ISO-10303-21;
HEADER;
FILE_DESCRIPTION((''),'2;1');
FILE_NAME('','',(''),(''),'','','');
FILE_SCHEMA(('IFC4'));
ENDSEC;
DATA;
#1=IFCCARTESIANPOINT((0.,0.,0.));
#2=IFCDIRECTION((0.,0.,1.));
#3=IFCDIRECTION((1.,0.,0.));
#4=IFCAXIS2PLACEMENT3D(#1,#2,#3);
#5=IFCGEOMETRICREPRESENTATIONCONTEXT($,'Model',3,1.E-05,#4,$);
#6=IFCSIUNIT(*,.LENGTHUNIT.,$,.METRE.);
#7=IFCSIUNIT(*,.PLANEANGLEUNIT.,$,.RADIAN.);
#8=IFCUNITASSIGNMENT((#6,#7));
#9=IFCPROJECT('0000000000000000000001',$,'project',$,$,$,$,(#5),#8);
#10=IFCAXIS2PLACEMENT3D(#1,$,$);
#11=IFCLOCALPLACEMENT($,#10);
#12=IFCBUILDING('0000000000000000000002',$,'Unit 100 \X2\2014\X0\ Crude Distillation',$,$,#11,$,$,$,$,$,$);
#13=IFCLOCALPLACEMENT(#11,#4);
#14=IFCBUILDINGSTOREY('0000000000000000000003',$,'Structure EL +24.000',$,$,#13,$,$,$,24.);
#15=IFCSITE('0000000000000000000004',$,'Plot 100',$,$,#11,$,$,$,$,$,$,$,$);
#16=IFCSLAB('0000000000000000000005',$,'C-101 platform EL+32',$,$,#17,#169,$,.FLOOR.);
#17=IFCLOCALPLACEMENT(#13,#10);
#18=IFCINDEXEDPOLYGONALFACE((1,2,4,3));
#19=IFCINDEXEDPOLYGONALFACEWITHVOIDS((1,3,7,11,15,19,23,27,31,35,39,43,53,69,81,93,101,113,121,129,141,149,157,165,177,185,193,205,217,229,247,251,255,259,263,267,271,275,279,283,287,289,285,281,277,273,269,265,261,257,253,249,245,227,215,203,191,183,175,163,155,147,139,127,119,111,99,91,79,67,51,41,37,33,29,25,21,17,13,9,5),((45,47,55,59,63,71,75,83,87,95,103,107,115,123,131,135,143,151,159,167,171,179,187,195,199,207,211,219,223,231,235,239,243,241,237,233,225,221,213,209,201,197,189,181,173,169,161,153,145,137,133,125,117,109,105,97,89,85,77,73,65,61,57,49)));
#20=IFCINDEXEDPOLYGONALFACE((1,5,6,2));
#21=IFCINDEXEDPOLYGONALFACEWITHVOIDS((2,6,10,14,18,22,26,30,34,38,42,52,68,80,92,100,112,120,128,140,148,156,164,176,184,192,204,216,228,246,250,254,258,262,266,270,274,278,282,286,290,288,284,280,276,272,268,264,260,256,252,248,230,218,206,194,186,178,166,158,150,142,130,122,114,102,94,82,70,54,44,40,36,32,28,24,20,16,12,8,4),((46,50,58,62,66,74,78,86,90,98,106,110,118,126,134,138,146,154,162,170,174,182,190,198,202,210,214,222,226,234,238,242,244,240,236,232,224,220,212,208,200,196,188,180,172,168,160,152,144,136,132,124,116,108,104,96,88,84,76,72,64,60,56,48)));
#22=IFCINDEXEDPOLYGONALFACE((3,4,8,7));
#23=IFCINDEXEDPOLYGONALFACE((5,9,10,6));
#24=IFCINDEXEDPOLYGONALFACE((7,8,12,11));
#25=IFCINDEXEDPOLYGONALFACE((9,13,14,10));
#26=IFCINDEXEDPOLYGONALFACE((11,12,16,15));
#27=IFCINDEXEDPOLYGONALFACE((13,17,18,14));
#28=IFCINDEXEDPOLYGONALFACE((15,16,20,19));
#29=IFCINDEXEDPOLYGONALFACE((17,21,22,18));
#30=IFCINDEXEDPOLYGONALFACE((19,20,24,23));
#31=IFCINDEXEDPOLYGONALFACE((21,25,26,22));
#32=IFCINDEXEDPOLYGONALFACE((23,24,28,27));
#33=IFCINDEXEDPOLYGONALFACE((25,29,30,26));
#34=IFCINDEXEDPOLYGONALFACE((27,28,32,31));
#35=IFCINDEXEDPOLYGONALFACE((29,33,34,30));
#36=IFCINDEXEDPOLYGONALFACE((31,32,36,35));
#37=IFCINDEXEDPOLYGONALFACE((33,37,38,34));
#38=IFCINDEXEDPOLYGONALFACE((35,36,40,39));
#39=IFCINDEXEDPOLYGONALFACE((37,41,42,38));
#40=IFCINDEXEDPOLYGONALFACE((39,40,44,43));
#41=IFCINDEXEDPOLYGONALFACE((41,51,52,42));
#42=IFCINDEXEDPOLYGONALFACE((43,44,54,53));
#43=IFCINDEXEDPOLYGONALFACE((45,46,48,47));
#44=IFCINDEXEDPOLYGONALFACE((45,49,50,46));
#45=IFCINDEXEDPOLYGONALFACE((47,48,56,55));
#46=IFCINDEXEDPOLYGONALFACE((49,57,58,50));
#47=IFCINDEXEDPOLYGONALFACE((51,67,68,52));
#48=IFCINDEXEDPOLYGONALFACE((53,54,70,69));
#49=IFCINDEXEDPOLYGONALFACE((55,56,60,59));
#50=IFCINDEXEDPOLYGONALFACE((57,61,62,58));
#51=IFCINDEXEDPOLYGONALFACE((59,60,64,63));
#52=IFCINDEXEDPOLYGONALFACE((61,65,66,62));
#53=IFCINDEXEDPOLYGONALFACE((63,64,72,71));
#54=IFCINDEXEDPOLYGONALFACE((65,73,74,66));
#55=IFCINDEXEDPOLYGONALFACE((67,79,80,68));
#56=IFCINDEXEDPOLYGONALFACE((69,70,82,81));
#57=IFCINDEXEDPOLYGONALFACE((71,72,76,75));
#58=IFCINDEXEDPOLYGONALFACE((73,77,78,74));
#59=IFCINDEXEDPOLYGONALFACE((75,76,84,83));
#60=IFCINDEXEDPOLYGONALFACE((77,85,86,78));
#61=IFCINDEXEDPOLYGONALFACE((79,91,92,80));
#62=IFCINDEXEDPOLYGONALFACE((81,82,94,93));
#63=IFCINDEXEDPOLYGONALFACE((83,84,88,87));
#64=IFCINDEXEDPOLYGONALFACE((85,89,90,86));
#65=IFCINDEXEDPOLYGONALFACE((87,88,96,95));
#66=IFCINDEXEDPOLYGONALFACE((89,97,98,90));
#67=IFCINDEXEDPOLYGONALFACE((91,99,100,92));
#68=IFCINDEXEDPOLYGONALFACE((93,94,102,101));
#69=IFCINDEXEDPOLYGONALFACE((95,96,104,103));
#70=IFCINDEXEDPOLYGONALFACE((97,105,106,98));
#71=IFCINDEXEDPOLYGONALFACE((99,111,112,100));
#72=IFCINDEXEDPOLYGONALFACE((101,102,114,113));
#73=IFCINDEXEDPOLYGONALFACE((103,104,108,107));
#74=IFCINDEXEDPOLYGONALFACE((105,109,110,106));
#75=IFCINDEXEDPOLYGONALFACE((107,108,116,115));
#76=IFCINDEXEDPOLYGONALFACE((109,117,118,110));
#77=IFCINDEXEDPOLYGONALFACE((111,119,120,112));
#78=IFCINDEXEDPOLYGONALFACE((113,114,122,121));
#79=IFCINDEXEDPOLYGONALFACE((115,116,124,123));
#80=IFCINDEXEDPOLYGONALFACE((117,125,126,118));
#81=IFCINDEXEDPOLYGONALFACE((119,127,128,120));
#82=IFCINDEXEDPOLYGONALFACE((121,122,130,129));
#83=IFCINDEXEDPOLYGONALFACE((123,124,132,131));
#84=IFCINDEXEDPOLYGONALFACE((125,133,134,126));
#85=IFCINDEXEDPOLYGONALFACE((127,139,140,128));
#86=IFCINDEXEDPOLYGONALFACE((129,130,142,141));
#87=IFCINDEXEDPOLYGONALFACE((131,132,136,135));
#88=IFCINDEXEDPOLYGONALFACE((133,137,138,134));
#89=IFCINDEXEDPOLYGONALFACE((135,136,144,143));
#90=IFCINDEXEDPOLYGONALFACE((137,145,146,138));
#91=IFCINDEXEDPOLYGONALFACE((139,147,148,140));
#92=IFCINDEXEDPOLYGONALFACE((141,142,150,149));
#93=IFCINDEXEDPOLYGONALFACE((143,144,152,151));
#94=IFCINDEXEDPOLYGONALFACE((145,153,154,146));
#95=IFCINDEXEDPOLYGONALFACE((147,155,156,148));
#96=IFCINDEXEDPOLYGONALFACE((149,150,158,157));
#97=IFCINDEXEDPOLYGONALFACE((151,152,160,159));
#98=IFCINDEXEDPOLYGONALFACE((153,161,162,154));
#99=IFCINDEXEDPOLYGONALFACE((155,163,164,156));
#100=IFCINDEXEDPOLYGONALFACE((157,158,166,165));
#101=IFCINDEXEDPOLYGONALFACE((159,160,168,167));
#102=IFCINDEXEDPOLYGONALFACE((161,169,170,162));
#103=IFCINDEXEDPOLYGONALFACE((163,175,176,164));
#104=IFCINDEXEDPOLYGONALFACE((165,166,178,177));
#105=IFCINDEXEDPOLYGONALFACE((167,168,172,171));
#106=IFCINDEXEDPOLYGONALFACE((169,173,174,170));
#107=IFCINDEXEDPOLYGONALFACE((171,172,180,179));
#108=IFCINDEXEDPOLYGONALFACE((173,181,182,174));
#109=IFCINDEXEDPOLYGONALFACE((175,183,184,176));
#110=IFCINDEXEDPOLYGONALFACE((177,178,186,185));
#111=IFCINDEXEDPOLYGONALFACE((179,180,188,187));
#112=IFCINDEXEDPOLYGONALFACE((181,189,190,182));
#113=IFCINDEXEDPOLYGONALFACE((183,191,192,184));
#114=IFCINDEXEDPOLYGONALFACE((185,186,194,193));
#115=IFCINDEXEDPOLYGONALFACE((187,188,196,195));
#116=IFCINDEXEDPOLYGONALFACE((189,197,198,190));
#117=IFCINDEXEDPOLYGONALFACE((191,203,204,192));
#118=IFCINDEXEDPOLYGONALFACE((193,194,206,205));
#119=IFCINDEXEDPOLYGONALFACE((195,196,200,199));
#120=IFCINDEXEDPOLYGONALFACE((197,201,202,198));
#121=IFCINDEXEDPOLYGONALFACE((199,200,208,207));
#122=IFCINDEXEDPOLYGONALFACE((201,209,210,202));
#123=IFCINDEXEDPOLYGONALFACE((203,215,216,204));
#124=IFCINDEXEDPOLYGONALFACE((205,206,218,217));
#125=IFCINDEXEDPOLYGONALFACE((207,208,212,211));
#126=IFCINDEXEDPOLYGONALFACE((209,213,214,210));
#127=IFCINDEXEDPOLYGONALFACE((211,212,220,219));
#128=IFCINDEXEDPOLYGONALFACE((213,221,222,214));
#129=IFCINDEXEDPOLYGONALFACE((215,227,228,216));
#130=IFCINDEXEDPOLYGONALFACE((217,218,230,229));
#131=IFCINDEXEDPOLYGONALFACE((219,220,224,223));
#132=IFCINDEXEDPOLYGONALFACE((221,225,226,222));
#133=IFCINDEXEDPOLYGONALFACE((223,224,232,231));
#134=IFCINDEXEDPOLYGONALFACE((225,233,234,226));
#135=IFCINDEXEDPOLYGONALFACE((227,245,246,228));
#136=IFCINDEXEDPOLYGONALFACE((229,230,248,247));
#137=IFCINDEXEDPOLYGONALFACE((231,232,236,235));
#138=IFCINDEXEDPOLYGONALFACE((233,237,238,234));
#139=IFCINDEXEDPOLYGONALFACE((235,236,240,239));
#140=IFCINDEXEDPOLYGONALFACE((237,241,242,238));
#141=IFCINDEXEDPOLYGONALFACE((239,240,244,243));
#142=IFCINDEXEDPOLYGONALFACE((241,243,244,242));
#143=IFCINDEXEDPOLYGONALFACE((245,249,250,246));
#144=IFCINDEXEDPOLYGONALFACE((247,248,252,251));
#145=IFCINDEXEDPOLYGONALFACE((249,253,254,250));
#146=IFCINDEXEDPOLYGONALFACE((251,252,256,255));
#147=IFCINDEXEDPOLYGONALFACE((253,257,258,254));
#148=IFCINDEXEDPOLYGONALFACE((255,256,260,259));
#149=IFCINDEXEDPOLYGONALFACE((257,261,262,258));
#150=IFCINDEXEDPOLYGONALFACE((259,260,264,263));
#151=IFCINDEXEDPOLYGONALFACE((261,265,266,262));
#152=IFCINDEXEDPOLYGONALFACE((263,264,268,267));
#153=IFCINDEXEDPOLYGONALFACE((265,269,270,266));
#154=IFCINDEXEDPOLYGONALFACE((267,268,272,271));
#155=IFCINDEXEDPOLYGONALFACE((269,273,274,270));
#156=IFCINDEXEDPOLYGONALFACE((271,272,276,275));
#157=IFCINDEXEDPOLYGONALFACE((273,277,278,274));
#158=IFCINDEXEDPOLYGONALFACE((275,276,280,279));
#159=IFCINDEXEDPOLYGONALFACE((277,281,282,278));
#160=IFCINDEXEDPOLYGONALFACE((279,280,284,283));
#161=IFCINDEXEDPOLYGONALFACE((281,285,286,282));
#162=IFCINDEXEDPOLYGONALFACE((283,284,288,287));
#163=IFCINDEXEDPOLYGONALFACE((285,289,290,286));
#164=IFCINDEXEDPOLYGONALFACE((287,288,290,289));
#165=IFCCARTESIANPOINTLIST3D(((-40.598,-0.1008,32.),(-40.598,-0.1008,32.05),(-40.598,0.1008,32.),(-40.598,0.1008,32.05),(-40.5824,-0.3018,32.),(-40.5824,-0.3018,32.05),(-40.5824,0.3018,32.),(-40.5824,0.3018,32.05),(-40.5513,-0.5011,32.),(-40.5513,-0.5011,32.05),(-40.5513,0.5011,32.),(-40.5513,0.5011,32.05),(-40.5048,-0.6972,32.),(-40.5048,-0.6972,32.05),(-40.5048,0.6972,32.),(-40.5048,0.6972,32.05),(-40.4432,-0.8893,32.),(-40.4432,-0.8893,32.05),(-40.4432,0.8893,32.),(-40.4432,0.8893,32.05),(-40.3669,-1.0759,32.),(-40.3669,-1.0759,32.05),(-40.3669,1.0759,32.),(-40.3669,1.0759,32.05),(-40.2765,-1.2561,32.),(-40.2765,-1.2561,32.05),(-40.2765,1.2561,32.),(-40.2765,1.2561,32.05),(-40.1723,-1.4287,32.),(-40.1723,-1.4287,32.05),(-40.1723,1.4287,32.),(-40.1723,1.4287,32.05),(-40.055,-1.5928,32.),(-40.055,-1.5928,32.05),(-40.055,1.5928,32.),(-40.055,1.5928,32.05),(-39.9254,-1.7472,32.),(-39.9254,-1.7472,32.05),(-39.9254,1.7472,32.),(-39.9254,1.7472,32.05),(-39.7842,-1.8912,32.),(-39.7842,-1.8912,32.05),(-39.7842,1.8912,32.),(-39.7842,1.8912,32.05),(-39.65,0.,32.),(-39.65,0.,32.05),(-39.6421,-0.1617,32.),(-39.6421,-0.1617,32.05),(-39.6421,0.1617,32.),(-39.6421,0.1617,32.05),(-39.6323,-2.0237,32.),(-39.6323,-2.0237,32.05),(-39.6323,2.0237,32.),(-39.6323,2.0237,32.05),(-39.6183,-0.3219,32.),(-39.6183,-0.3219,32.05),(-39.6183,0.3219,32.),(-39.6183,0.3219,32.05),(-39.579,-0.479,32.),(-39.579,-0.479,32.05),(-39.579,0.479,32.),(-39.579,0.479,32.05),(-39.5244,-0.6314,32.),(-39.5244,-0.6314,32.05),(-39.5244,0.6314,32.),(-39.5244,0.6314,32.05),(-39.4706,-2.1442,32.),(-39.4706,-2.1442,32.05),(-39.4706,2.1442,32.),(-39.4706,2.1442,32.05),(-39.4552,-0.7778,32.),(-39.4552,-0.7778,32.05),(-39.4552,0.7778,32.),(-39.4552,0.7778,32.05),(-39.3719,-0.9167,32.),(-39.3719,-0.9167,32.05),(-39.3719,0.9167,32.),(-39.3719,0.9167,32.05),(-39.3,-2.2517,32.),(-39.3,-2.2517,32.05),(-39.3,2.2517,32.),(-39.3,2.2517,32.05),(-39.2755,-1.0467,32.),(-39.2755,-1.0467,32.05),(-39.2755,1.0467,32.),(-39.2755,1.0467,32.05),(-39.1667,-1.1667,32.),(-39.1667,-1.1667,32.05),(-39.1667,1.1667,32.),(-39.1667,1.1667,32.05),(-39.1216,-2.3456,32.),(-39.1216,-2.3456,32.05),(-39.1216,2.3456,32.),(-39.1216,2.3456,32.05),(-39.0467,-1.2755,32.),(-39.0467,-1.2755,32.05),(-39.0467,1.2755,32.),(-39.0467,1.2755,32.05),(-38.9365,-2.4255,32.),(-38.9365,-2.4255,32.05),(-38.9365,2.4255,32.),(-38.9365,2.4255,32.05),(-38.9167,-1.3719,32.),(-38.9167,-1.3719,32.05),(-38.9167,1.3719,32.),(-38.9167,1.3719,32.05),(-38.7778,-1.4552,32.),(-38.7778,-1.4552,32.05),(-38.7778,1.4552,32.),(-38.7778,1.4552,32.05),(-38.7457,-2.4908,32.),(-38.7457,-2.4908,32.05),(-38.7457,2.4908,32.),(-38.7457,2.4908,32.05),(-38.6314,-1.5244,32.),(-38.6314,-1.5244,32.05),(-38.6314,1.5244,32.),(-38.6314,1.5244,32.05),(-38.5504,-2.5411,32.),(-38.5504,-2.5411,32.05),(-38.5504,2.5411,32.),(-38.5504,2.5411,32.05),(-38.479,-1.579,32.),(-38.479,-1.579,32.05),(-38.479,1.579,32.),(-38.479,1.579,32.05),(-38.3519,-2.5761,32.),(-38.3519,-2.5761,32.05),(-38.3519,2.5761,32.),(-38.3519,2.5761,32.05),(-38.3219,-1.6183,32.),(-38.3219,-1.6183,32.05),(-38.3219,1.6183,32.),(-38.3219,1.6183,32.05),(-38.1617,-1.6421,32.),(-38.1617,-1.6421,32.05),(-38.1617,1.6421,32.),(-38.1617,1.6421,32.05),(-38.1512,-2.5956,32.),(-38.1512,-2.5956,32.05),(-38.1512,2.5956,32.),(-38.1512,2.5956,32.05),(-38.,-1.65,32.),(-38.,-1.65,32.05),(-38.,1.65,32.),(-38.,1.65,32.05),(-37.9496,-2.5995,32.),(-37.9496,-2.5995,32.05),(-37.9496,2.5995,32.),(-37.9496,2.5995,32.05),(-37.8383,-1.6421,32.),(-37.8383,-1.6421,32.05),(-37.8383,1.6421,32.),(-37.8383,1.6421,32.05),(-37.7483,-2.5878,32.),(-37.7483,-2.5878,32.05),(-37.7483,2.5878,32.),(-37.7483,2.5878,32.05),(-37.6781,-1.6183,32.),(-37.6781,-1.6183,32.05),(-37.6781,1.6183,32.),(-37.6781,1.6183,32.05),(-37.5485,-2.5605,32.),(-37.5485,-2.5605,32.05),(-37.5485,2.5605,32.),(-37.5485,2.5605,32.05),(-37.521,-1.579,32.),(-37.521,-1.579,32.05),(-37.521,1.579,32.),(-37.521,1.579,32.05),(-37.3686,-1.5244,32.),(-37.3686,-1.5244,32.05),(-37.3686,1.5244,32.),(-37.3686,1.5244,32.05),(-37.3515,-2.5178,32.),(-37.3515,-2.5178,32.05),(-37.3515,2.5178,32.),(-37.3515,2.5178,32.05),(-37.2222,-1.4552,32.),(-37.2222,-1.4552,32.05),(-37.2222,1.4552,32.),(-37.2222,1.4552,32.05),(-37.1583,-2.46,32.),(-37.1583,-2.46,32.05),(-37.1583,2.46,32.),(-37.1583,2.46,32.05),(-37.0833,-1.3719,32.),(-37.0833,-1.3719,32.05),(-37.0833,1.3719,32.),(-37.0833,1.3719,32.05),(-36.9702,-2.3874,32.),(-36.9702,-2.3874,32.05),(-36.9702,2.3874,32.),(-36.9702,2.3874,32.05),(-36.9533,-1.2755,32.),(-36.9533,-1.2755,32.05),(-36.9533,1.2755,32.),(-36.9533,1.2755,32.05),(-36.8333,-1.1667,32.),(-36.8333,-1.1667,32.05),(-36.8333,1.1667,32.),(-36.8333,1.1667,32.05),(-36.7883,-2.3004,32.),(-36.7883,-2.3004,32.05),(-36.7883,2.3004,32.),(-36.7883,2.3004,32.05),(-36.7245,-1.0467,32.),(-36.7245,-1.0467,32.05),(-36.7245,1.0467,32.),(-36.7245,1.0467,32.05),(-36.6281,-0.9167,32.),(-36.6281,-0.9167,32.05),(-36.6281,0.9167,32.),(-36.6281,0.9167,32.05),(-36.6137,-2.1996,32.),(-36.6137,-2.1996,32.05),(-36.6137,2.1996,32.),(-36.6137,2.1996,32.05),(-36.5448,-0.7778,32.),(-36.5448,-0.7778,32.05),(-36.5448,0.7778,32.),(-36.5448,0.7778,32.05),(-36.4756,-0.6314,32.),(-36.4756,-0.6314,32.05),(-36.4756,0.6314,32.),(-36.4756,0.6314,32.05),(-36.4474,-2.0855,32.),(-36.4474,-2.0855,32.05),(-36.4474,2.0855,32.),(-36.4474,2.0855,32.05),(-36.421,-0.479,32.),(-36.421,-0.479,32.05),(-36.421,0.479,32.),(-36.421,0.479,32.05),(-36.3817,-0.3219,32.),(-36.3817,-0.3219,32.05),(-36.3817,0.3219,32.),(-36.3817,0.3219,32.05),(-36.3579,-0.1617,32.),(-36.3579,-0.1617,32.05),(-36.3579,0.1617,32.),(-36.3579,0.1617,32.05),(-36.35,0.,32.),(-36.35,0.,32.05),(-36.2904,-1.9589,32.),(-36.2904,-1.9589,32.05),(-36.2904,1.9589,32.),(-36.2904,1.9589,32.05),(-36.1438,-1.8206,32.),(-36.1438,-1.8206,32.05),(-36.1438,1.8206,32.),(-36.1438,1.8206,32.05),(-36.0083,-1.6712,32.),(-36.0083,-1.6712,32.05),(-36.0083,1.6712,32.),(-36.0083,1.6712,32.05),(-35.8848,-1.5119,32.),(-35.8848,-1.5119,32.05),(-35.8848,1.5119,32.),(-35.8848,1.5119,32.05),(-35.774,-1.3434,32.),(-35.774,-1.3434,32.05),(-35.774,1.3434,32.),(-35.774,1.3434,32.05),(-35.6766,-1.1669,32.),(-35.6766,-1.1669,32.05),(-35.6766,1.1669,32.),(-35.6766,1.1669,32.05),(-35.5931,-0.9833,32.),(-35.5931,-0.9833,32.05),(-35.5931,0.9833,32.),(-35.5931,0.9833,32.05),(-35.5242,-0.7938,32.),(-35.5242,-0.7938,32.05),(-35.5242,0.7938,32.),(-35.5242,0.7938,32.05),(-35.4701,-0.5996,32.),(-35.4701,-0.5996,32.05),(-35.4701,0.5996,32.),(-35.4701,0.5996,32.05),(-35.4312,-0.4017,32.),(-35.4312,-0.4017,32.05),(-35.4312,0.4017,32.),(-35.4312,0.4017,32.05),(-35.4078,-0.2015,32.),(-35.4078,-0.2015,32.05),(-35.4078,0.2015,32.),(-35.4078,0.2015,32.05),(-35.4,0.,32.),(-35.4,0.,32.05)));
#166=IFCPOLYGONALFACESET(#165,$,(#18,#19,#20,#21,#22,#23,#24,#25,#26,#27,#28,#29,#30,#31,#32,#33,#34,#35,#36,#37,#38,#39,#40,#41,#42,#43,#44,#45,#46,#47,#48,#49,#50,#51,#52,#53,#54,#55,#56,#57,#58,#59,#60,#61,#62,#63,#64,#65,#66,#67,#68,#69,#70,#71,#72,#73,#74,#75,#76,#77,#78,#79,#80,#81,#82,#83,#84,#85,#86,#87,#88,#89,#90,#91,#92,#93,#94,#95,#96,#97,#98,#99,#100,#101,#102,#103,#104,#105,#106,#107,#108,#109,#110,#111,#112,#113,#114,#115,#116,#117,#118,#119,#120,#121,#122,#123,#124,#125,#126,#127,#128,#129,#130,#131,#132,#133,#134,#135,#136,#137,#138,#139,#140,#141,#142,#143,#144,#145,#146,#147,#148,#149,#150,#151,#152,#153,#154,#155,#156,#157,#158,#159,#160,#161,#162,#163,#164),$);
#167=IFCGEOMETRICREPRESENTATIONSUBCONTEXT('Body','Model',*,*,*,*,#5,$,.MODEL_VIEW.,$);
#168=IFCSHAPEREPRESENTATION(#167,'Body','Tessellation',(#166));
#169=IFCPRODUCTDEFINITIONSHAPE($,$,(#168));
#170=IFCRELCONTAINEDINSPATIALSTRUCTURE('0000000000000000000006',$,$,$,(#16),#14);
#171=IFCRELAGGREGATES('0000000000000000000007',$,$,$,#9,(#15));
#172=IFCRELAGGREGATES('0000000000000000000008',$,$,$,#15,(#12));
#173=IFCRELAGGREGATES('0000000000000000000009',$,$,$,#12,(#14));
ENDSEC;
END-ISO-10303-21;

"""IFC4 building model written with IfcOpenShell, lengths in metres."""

from ifc_helpers import new_model, si_unit, frame, origin, origin_with_axes, origin_2d, place, context, subcontext, project, spatial, hollow_circle, extrude, element, save


model = new_model("IFC4")

# Units and contexts
model_context = context("Model", 3, precision=1e-05, world=origin_with_axes())
body_context = subcontext(model_context, "Body", "Model", "MODEL_VIEW")
ifc_project = project(units=[si_unit("LENGTHUNIT", "METRE"), si_unit("PLANEANGLEUNIT", "RADIAN")], contexts=[model_context])

# Site, building, storey
placement = place(None, origin())
site = spatial("IfcSite", under=ifc_project, at=placement, Name="Plot 100")
building = spatial("IfcBuilding", under=site, at=placement, Name="Unit 100 — Crude Distillation")
storey_placement = place(placement, origin_with_axes())
storey = spatial("IfcBuildingStorey", under=building, at=storey_placement, Name="Structure EL +24.000", Elevation=24.0)

# Slab
slab_1_placement = place(storey_placement, origin_with_axes())
element("IfcSlab", 1, at=slab_1_placement, inside=storey, Name="C-101 platform EL+32", PredefinedType="FLOOR", context=body_context, shape_type="SweptSolid", body=[
    extrude(hollow_circle(Radius=2.6, WallThickness=0.95, at=origin_2d()), frame((-38.0, 0.0, 32.0), z_axis=(0.0, 0.0, 1.0), x_axis=(1.0, 0.0, 0.0)), (0.0, 0.0, 1.0), 0.05),
])

save(model, "model.ifc")
